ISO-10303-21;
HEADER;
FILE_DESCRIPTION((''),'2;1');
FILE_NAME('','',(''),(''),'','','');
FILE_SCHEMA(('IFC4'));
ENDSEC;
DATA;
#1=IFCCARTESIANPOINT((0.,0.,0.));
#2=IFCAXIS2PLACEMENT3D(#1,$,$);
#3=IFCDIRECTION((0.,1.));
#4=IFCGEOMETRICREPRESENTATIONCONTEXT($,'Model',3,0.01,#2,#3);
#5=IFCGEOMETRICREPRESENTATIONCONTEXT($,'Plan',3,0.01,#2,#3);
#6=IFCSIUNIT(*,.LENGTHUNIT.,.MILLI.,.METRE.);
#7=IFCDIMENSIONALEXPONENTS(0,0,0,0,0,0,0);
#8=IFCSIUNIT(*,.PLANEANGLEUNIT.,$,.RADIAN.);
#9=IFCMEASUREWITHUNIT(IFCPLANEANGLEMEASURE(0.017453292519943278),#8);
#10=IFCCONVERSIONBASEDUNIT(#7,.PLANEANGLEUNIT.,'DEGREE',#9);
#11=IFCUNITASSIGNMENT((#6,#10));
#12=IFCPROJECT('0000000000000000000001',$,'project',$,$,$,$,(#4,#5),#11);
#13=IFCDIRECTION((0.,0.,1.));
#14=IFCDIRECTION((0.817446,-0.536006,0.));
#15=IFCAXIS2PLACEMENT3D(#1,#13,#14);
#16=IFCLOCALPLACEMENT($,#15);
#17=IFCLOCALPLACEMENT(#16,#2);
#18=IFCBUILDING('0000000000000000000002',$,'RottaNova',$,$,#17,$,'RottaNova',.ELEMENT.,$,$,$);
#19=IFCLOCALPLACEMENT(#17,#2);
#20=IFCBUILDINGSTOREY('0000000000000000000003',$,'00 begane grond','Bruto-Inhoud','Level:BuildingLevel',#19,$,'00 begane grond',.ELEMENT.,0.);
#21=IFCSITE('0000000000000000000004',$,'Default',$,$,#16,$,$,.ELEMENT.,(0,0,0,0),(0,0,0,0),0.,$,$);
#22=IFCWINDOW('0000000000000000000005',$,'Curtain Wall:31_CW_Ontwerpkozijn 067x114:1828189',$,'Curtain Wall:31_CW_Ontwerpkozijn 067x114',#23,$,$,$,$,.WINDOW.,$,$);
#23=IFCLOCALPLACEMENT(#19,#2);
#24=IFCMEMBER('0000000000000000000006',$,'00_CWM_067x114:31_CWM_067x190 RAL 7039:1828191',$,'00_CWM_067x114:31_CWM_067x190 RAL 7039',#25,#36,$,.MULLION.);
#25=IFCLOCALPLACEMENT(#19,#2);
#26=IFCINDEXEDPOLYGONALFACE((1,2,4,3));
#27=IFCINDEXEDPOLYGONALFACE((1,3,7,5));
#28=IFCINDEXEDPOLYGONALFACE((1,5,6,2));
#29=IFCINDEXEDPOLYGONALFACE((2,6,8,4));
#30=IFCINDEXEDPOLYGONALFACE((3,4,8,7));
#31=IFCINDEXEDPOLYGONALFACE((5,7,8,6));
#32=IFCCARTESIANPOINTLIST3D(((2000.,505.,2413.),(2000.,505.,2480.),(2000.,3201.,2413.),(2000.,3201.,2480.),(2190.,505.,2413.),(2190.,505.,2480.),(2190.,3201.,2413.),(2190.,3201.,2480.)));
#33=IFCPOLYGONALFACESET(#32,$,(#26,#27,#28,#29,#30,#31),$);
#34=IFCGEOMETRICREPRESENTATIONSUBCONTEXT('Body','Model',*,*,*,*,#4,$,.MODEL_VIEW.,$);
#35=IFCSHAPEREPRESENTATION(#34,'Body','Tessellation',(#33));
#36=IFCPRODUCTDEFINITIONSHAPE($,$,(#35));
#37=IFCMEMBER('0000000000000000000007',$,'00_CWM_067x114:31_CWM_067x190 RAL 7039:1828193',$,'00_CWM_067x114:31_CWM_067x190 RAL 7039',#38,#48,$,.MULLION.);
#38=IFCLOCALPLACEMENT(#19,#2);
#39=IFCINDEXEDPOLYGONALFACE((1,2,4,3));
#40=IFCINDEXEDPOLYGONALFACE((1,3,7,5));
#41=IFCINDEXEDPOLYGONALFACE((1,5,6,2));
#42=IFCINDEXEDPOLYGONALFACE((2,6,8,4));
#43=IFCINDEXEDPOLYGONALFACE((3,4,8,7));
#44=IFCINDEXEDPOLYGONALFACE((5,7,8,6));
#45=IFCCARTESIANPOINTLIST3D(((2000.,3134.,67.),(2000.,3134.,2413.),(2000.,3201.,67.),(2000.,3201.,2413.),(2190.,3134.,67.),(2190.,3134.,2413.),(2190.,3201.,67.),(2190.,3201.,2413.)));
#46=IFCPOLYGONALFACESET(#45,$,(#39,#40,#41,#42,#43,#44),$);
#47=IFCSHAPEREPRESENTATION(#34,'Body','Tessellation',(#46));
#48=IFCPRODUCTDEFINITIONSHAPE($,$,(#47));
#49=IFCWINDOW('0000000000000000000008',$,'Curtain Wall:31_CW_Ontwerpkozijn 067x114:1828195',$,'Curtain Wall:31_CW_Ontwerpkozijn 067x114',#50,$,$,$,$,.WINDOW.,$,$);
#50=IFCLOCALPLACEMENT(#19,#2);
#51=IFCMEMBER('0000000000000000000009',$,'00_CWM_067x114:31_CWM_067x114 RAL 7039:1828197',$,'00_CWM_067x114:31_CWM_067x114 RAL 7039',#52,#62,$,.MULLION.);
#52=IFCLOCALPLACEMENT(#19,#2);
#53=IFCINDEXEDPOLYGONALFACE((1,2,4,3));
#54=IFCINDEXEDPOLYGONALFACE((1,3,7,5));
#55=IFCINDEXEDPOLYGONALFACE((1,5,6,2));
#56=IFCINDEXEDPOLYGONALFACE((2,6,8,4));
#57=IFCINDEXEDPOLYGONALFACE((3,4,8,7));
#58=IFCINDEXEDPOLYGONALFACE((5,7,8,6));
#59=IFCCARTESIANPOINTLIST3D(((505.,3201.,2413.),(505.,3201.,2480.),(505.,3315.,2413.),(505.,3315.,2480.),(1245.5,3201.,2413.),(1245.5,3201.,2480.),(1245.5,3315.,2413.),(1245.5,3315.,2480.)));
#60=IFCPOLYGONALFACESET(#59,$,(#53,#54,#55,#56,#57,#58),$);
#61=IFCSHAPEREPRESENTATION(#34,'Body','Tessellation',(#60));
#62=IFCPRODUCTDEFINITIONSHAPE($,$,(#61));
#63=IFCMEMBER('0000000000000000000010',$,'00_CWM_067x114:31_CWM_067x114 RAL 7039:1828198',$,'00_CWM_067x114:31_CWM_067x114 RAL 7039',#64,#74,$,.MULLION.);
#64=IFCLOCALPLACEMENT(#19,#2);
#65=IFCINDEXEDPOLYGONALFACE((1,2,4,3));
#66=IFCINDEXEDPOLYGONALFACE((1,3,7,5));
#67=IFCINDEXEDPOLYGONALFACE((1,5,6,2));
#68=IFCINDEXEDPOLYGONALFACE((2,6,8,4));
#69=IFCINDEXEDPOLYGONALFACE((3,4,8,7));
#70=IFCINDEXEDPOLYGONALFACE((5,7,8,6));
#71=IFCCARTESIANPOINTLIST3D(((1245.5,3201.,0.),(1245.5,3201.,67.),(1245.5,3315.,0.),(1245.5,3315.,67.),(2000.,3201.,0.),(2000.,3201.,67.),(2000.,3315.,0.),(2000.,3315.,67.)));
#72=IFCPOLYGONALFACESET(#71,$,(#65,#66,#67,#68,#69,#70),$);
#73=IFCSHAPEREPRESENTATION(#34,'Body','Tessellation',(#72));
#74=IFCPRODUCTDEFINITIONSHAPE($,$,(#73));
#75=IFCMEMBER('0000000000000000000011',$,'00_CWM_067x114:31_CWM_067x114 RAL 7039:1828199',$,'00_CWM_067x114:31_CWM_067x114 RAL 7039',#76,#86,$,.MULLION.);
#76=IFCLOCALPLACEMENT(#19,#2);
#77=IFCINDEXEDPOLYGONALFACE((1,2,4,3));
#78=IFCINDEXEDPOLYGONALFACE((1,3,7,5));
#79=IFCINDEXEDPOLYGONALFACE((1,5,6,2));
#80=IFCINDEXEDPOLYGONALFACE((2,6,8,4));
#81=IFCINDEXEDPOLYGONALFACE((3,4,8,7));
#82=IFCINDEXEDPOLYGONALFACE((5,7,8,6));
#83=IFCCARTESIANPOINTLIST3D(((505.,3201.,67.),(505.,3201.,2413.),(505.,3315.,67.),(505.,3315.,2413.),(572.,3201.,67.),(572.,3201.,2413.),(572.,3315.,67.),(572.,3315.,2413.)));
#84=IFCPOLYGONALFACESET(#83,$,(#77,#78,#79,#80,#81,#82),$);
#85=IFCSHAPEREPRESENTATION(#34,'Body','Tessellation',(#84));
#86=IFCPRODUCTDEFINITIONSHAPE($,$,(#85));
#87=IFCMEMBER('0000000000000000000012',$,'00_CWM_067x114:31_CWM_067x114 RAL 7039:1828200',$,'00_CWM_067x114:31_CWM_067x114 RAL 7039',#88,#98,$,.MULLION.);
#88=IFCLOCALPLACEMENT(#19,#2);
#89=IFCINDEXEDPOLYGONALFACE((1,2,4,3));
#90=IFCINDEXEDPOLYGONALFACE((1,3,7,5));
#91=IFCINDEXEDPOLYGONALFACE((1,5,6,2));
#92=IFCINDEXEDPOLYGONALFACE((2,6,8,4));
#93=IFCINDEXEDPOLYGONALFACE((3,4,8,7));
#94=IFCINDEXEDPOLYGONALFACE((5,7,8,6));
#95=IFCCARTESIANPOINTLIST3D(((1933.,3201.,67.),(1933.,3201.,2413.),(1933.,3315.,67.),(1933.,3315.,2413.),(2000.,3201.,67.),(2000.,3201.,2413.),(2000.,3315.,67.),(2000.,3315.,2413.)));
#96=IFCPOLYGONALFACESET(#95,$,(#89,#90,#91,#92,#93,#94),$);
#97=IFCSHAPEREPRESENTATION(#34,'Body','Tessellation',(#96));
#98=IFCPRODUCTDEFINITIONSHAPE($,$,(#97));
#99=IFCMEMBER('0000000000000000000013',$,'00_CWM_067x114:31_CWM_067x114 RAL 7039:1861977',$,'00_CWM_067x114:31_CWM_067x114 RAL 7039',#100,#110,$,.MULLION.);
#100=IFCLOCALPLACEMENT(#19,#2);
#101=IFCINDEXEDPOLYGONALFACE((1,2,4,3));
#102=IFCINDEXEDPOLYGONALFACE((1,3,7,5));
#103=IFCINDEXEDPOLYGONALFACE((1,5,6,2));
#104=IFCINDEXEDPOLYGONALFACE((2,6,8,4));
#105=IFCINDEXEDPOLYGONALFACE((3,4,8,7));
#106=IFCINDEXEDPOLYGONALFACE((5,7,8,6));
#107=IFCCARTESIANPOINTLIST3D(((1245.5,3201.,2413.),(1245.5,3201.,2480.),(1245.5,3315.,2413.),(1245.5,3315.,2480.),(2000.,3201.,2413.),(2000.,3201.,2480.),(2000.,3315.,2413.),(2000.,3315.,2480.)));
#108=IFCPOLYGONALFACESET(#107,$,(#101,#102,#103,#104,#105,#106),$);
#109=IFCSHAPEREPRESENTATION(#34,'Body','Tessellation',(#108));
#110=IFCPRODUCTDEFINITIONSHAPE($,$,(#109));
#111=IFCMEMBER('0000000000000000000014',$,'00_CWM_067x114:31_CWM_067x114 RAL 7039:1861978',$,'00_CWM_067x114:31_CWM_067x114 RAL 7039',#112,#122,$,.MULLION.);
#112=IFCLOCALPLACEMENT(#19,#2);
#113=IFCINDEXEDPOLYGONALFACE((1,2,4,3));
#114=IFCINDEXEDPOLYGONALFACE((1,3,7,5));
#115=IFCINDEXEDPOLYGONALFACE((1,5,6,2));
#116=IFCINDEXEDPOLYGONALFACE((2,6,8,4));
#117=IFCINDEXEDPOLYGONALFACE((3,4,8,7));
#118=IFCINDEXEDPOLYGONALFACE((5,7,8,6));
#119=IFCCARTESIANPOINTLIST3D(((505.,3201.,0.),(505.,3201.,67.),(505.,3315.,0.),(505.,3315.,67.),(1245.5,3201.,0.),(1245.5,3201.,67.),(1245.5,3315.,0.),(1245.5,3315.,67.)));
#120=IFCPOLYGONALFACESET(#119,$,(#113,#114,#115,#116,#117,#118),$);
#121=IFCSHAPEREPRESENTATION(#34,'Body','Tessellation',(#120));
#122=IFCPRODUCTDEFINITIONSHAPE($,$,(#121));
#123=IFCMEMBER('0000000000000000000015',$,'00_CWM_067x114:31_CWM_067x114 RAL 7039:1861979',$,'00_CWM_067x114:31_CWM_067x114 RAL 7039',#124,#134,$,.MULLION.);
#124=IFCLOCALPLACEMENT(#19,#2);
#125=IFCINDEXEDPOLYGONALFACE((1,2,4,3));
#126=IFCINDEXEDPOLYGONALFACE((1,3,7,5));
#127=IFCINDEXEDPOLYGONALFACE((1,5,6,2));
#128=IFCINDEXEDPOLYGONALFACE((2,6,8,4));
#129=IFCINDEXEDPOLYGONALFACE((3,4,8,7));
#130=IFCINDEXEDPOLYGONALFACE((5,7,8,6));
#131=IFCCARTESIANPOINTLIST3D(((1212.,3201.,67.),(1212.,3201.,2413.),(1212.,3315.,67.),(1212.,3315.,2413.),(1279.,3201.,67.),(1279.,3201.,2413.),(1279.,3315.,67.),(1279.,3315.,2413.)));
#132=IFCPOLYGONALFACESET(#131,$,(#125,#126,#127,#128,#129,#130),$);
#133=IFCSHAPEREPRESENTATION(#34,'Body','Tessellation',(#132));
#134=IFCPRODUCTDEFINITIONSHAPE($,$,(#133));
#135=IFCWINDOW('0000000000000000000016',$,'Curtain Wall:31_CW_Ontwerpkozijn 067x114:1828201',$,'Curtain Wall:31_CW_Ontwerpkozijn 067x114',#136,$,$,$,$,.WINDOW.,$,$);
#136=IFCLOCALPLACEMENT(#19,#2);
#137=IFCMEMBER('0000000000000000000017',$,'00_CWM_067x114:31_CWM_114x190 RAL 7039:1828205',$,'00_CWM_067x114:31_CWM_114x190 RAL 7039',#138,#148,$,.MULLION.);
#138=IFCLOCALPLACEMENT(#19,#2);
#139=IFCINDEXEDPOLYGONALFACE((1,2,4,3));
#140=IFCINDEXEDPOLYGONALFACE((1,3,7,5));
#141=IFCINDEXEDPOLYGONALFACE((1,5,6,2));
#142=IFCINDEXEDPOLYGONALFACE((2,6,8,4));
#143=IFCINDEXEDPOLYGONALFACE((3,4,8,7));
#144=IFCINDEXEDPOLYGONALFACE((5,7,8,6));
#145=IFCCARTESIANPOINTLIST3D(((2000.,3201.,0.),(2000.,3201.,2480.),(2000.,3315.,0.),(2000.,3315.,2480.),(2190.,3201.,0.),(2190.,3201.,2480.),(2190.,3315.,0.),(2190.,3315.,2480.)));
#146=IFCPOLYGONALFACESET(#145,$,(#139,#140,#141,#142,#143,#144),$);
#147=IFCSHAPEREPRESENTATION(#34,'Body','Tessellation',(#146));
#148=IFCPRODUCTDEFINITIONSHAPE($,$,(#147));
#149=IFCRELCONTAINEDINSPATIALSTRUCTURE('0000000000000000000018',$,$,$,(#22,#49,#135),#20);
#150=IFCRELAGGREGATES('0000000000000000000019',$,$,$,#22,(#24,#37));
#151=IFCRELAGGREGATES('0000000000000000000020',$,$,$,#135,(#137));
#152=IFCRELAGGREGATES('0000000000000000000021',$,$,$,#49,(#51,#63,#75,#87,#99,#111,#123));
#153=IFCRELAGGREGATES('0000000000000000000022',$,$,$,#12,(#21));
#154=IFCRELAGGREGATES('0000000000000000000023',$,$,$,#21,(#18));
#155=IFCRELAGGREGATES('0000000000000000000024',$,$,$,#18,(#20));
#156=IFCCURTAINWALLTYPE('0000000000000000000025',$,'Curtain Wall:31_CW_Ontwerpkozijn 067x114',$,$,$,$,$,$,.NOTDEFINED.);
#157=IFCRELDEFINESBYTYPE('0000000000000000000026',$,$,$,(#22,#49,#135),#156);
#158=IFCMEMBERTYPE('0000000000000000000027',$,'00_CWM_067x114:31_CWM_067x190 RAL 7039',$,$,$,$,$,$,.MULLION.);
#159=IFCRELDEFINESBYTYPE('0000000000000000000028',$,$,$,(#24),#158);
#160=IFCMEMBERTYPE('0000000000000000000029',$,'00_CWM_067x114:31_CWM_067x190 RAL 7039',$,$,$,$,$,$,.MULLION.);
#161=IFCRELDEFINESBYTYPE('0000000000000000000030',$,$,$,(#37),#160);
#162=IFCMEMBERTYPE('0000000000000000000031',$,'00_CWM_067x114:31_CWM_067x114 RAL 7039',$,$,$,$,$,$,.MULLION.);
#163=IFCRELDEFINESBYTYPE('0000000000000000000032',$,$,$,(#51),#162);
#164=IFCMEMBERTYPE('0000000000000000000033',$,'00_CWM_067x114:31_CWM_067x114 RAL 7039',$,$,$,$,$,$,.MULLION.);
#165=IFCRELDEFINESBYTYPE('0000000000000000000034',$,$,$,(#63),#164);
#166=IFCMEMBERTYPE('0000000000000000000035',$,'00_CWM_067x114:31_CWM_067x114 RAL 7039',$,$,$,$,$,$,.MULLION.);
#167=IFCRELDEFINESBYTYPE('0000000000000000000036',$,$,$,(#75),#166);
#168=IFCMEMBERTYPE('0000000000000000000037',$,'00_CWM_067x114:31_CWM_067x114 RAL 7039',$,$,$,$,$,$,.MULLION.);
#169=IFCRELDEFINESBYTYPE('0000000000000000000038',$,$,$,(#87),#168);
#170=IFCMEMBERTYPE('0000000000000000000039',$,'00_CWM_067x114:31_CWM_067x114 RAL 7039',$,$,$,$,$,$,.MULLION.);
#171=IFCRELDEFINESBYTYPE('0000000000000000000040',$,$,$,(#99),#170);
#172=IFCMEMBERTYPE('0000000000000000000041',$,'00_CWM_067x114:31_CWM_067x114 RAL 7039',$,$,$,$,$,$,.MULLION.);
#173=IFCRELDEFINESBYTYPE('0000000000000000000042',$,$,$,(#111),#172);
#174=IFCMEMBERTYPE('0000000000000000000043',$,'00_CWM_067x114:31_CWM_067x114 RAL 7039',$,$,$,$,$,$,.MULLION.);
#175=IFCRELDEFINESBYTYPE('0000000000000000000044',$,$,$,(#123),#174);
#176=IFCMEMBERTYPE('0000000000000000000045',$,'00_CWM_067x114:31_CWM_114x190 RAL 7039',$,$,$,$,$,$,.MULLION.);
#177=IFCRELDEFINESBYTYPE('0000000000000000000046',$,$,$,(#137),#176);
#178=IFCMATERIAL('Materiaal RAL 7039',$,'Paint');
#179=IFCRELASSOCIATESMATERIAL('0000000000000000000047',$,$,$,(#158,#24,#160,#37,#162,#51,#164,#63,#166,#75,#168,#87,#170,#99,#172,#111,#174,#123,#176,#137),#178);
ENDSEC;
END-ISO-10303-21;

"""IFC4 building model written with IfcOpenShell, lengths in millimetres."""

from ifc_helpers import new_model, entity, si_unit, converted_unit, direction, frame, origin, place, context, subcontext, project, spatial, indexed_curve, outline, extrude, source, transform, mapped, material, type_object, type_shapes, element, aggregate, save


model = new_model("IFC4")

# Units and contexts
model_context = context("Model", 3, precision=0.01, world=origin(), true_north=direction((0.0, 1.0)))
plan_context = context("Plan", 3, precision=0.01, world=origin(), true_north=direction((0.0, 1.0)))
body_context = subcontext(model_context, "Body", "Model", "MODEL_VIEW")
ifc_project = project(units=[si_unit("LENGTHUNIT", "METRE", prefix="MILLI"), converted_unit("PLANEANGLEUNIT", "DEGREE", entity("IfcPlaneAngleMeasure", 0.017453292519943278), si_unit("PLANEANGLEUNIT", "RADIAN"), dimensions=[0, 0, 0, 0, 0, 0, 0])], contexts=[model_context, plan_context])

# Site, building, storey
site_placement = place(None, frame((0.0, 0.0, 0.0), z_axis=(0.0, 0.0, 1.0), x_axis=(0.817446, -0.536006, 0.0)))
site = spatial("IfcSite", under=ifc_project, at=site_placement, Name="Default", CompositionType="ELEMENT", RefLatitude=(0, 0, 0, 0), RefLongitude=(0, 0, 0, 0), RefElevation=0.0)
building_placement = place(site_placement, origin())
building = spatial("IfcBuilding", under=site, at=building_placement, Name="RottaNova", LongName="RottaNova", CompositionType="ELEMENT")
storey_placement = place(building_placement, origin())
storey = spatial("IfcBuildingStorey", under=building, at=storey_placement, Name="00 begane grond", Description="Bruto-Inhoud", ObjectType="Level:BuildingLevel", LongName="00 begane grond", CompositionType="ELEMENT", Elevation=0.0)

# Windows, members
curtain_wall_type = type_object("IfcCurtainWallType", Name="Curtain Wall:31_CW_Ontwerpkozijn 067x114", PredefinedType="NOTDEFINED")
window_1_placement = place(storey_placement, origin())
window_1 = element("IfcWindow", 1, at=window_1_placement, inside=storey, type_object=curtain_wall_type, Name="Curtain Wall:31_CW_Ontwerpkozijn 067x114:1828189", ObjectType="Curtain Wall:31_CW_Ontwerpkozijn 067x114", PredefinedType="WINDOW")
ifc_material_1 = material(Name="Materiaal RAL 7039", Category="Paint")
member_type_1 = type_object("IfcMemberType", Name="00_CWM_067x114:31_CWM_067x190 RAL 7039", PredefinedType="MULLION", material=ifc_material_1)
shared_shape_1 = source(origin(), body_context, "Body", "SweptSolid", [
    extrude(outline(indexed_curve([(-33.5, -95.0), (33.5, -95.0), (33.5, 95.0), (-33.5, 95.0), (-33.5, -95.0)], self_intersect=False)), frame((-33.5, -95.0, -2696.0), z_axis=(0.0, 0.0, 1.0), x_axis=(-1.0, 0.0, 0.0)), (0.0, 0.0, 1.0), 2696.0),
])
type_shapes(member_type_1, [shared_shape_1])
member_1_placement = place(window_1_placement, frame((2190.0, 3201.0, 2480.0), z_axis=(0.0, 1.0, 0.0), x_axis=(0.0, 0.0, 1.0)))
member_1 = element("IfcMember", 2, at=member_1_placement, type_object=member_type_1, material=ifc_material_1, Name="00_CWM_067x114:31_CWM_067x190 RAL 7039:1828191", ObjectType="00_CWM_067x114:31_CWM_067x190 RAL 7039", PredefinedType="MULLION", context=body_context, shape_type="MappedRepresentation", body=[
    mapped(shared_shape_1, transform((0.0, 0.0, 0.0), scale=1.0)),
])
member_type_2 = type_object("IfcMemberType", Name="00_CWM_067x114:31_CWM_067x190 RAL 7039", PredefinedType="MULLION", material=ifc_material_1)
shared_shape_2 = source(origin(), body_context, "Body", "SweptSolid", [
    extrude(outline(indexed_curve([(-33.5, -95.0), (33.5, -95.0), (33.5, 95.0), (-33.5, 95.0), (-33.5, -95.0)], self_intersect=False)), frame((-33.5, -95.0, -2346.0), z_axis=(0.0, 0.0, 1.0), x_axis=(-1.0, 0.0, 0.0)), (0.0, 0.0, 1.0), 2346.0),
])
type_shapes(member_type_2, [shared_shape_2])
member_2_placement = place(window_1_placement, frame((2190.0, 3201.0, 67.0), z_axis=(0.0, 0.0, -1.0), x_axis=(0.0, 1.0, 0.0)))
member_2 = element("IfcMember", 3, at=member_2_placement, type_object=member_type_2, material=ifc_material_1, Name="00_CWM_067x114:31_CWM_067x190 RAL 7039:1828193", ObjectType="00_CWM_067x114:31_CWM_067x190 RAL 7039", PredefinedType="MULLION", context=body_context, shape_type="MappedRepresentation", body=[
    mapped(shared_shape_2, transform((0.0, 0.0, 0.0), scale=1.0)),
])
aggregate(window_1, [member_1, member_2])
window_2_placement = place(storey_placement, origin())
window_2 = element("IfcWindow", 4, at=window_2_placement, inside=storey, type_object=curtain_wall_type, Name="Curtain Wall:31_CW_Ontwerpkozijn 067x114:1828195", ObjectType="Curtain Wall:31_CW_Ontwerpkozijn 067x114", PredefinedType="WINDOW")
member_type_3 = type_object("IfcMemberType", Name="00_CWM_067x114:31_CWM_067x114 RAL 7039", PredefinedType="MULLION", material=ifc_material_1)
shared_shape_3 = source(origin(), body_context, "Body", "SweptSolid", [
    extrude(outline(indexed_curve([(-33.5, -57.0), (33.5, -57.0), (33.5, 57.0), (-33.5, 57.0), (-33.5, -57.0)], self_intersect=False)), frame((-33.5, -57.0, -740.5), z_axis=(0.0, 0.0, 1.0), x_axis=(-1.0, 0.0, 0.0)), (0.0, 0.0, 1.0), 740.5),
])
type_shapes(member_type_3, [shared_shape_3])
member_3_placement = place(window_2_placement, frame((505.0, 3315.0, 2480.0), z_axis=(-1.0, 0.0, 0.0), x_axis=(0.0, 0.0, 1.0)))
member_3 = element("IfcMember", 5, at=member_3_placement, type_object=member_type_3, material=ifc_material_1, Name="00_CWM_067x114:31_CWM_067x114 RAL 7039:1828197", ObjectType="00_CWM_067x114:31_CWM_067x114 RAL 7039", PredefinedType="MULLION", context=body_context, shape_type="MappedRepresentation", body=[
    mapped(shared_shape_3, transform((0.0, 0.0, 0.0), scale=1.0)),
])
member_type_4 = type_object("IfcMemberType", Name="00_CWM_067x114:31_CWM_067x114 RAL 7039", PredefinedType="MULLION", material=ifc_material_1)
shared_shape_4 = source(origin(), body_context, "Body", "SweptSolid", [
    extrude(outline(indexed_curve([(-33.5, -57.0), (33.5, -57.0), (33.5, 57.0), (-33.5, 57.0), (-33.5, -57.0)], self_intersect=False)), frame((-33.5, -57.0, -754.5), z_axis=(0.0, 0.0, 1.0), x_axis=(-1.0, 0.0, 0.0)), (0.0, 0.0, 1.0), 754.5),
])
type_shapes(member_type_4, [shared_shape_4])
member_4_placement = place(window_2_placement, frame((2000.0, 3315.0, 0.0), z_axis=(1.0, 0.0, 0.0), x_axis=(0.0, 0.0, -1.0)))
member_4 = element("IfcMember", 6, at=member_4_placement, type_object=member_type_4, material=ifc_material_1, Name="00_CWM_067x114:31_CWM_067x114 RAL 7039:1828198", ObjectType="00_CWM_067x114:31_CWM_067x114 RAL 7039", PredefinedType="MULLION", context=body_context, shape_type="MappedRepresentation", body=[
    mapped(shared_shape_4, transform((0.0, 0.0, 0.0), scale=1.0)),
])
member_type_5 = type_object("IfcMemberType", Name="00_CWM_067x114:31_CWM_067x114 RAL 7039", PredefinedType="MULLION", material=ifc_material_1)
shared_shape_5 = source(origin(), body_context, "Body", "SweptSolid", [
    extrude(outline(indexed_curve([(-33.5, -57.0), (33.5, -57.0), (33.5, 57.0), (-33.5, 57.0), (-33.5, -57.0)], self_intersect=False)), frame((-33.5, -57.0, -2346.0), z_axis=(0.0, 0.0, 1.0), x_axis=(-1.0, 0.0, 0.0)), (0.0, 0.0, 1.0), 2346.0),
])
type_shapes(member_type_5, [shared_shape_5])
member_5_placement = place(window_2_placement, frame((505.0, 3315.0, 67.0), z_axis=(0.0, 0.0, -1.0), x_axis=(-1.0, 0.0, 0.0)))
member_5 = element("IfcMember", 7, at=member_5_placement, type_object=member_type_5, material=ifc_material_1, Name="00_CWM_067x114:31_CWM_067x114 RAL 7039:1828199", ObjectType="00_CWM_067x114:31_CWM_067x114 RAL 7039", PredefinedType="MULLION", context=body_context, shape_type="MappedRepresentation", body=[
    mapped(shared_shape_5, transform((0.0, 0.0, 0.0), scale=1.0)),
])
member_type_6 = type_object("IfcMemberType", Name="00_CWM_067x114:31_CWM_067x114 RAL 7039", PredefinedType="MULLION", material=ifc_material_1)
shared_shape_6 = source(origin(), body_context, "Body", "SweptSolid", [
    extrude(outline(indexed_curve([(-33.5, -57.0), (33.5, -57.0), (33.5, 57.0), (-33.5, 57.0), (-33.5, -57.0)], self_intersect=False)), frame((-33.5, -57.0, -2346.0), z_axis=(0.0, 0.0, 1.0), x_axis=(-1.0, 0.0, 0.0)), (0.0, 0.0, 1.0), 2346.0),
])
type_shapes(member_type_6, [shared_shape_6])
member_6_placement = place(window_2_placement, frame((2000.0, 3315.0, 2413.0)))
member_6 = element("IfcMember", 8, at=member_6_placement, type_object=member_type_6, material=ifc_material_1, Name="00_CWM_067x114:31_CWM_067x114 RAL 7039:1828200", ObjectType="00_CWM_067x114:31_CWM_067x114 RAL 7039", PredefinedType="MULLION", context=body_context, shape_type="MappedRepresentation", body=[
    mapped(shared_shape_6, transform((0.0, 0.0, 0.0), scale=1.0)),
])
member_type_7 = type_object("IfcMemberType", Name="00_CWM_067x114:31_CWM_067x114 RAL 7039", PredefinedType="MULLION", material=ifc_material_1)
shared_shape_7 = source(origin(), body_context, "Body", "SweptSolid", [
    extrude(outline(indexed_curve([(-33.5, -57.0), (33.5, -57.0), (33.5, 57.0), (-33.5, 57.0), (-33.5, -57.0)], self_intersect=False)), frame((-33.5, -57.0, -754.5), z_axis=(0.0, 0.0, 1.0), x_axis=(-1.0, 0.0, 0.0)), (0.0, 0.0, 1.0), 754.5),
])
type_shapes(member_type_7, [shared_shape_7])
member_7_placement = place(window_2_placement, frame((1245.5, 3315.0, 2480.0), z_axis=(-1.0, 0.0, 0.0), x_axis=(0.0, 0.0, 1.0)))
member_7 = element("IfcMember", 9, at=member_7_placement, type_object=member_type_7, material=ifc_material_1, Name="00_CWM_067x114:31_CWM_067x114 RAL 7039:1861977", ObjectType="00_CWM_067x114:31_CWM_067x114 RAL 7039", PredefinedType="MULLION", context=body_context, shape_type="MappedRepresentation", body=[
    mapped(shared_shape_7, transform((0.0, 0.0, 0.0), scale=1.0)),
])
member_type_8 = type_object("IfcMemberType", Name="00_CWM_067x114:31_CWM_067x114 RAL 7039", PredefinedType="MULLION", material=ifc_material_1)
shared_shape_8 = source(origin(), body_context, "Body", "SweptSolid", [
    extrude(outline(indexed_curve([(-33.5, -57.0), (33.5, -57.0), (33.5, 57.0), (-33.5, 57.0), (-33.5, -57.0)], self_intersect=False)), frame((-33.5, -57.0, -740.5), z_axis=(0.0, 0.0, 1.0), x_axis=(-1.0, 0.0, 0.0)), (0.0, 0.0, 1.0), 740.5),
])
type_shapes(member_type_8, [shared_shape_8])
member_8_placement = place(window_2_placement, frame((1245.5, 3315.0, 0.0), z_axis=(1.0, 0.0, 0.0), x_axis=(0.0, 0.0, -1.0)))
member_8 = element("IfcMember", 10, at=member_8_placement, type_object=member_type_8, material=ifc_material_1, Name="00_CWM_067x114:31_CWM_067x114 RAL 7039:1861978", ObjectType="00_CWM_067x114:31_CWM_067x114 RAL 7039", PredefinedType="MULLION", context=body_context, shape_type="MappedRepresentation", body=[
    mapped(shared_shape_8, transform((0.0, 0.0, 0.0), scale=1.0)),
])
member_type_9 = type_object("IfcMemberType", Name="00_CWM_067x114:31_CWM_067x114 RAL 7039", PredefinedType="MULLION", material=ifc_material_1)
shared_shape_9 = source(origin(), body_context, "Body", "SweptSolid", [
    extrude(outline(indexed_curve([(-33.5, -57.0), (33.5, -57.0), (33.5, 57.0), (-33.5, 57.0), (-33.5, -57.0)], self_intersect=False)), frame((0.0, -57.0, -2346.0), z_axis=(0.0, 0.0, 1.0), x_axis=(-1.0, 0.0, 0.0)), (0.0, 0.0, 1.0), 2346.0),
])
type_shapes(member_type_9, [shared_shape_9])
member_9_placement = place(window_2_placement, frame((1245.5, 3315.0, 67.0), z_axis=(0.0, 0.0, -1.0), x_axis=(-1.0, 0.0, 0.0)))
member_9 = element("IfcMember", 11, at=member_9_placement, type_object=member_type_9, material=ifc_material_1, Name="00_CWM_067x114:31_CWM_067x114 RAL 7039:1861979", ObjectType="00_CWM_067x114:31_CWM_067x114 RAL 7039", PredefinedType="MULLION", context=body_context, shape_type="MappedRepresentation", body=[
    mapped(shared_shape_9, transform((0.0, 0.0, 0.0), scale=1.0)),
])

# Window, member
window_3_placement = place(storey_placement, origin())
window_3 = element("IfcWindow", 12, at=window_3_placement, inside=storey, type_object=curtain_wall_type, Name="Curtain Wall:31_CW_Ontwerpkozijn 067x114:1828201", ObjectType="Curtain Wall:31_CW_Ontwerpkozijn 067x114", PredefinedType="WINDOW")
member_type_10 = type_object("IfcMemberType", Name="00_CWM_067x114:31_CWM_114x190 RAL 7039", PredefinedType="MULLION", material=ifc_material_1)
shared_shape_10 = source(origin(), body_context, "Body", "SweptSolid", [
    extrude(outline(indexed_curve([(-95.0, -57.0), (95.0, -57.0), (95.0, 57.0), (-95.0, 57.0), (-95.0, -57.0)], self_intersect=False)), frame((-95.0, 0.0, -2480.0)), (0.0, 0.0, 1.0), 2480.0),
])
type_shapes(member_type_10, [shared_shape_10])
member_10_placement = place(window_3_placement, frame((2190.0, 3258.0, 2480.0)))
member_10 = element("IfcMember", 13, at=member_10_placement, type_object=member_type_10, material=ifc_material_1, Name="00_CWM_067x114:31_CWM_114x190 RAL 7039:1828205", ObjectType="00_CWM_067x114:31_CWM_114x190 RAL 7039", PredefinedType="MULLION", context=body_context, shape_type="MappedRepresentation", body=[
    mapped(shared_shape_10, transform((0.0, 0.0, 0.0), scale=1.0)),
])
aggregate(window_3, [member_10])

aggregate(window_2, [member_3, member_4, member_5, member_6, member_7, member_8, member_9])

save(model, "model.ifc")
